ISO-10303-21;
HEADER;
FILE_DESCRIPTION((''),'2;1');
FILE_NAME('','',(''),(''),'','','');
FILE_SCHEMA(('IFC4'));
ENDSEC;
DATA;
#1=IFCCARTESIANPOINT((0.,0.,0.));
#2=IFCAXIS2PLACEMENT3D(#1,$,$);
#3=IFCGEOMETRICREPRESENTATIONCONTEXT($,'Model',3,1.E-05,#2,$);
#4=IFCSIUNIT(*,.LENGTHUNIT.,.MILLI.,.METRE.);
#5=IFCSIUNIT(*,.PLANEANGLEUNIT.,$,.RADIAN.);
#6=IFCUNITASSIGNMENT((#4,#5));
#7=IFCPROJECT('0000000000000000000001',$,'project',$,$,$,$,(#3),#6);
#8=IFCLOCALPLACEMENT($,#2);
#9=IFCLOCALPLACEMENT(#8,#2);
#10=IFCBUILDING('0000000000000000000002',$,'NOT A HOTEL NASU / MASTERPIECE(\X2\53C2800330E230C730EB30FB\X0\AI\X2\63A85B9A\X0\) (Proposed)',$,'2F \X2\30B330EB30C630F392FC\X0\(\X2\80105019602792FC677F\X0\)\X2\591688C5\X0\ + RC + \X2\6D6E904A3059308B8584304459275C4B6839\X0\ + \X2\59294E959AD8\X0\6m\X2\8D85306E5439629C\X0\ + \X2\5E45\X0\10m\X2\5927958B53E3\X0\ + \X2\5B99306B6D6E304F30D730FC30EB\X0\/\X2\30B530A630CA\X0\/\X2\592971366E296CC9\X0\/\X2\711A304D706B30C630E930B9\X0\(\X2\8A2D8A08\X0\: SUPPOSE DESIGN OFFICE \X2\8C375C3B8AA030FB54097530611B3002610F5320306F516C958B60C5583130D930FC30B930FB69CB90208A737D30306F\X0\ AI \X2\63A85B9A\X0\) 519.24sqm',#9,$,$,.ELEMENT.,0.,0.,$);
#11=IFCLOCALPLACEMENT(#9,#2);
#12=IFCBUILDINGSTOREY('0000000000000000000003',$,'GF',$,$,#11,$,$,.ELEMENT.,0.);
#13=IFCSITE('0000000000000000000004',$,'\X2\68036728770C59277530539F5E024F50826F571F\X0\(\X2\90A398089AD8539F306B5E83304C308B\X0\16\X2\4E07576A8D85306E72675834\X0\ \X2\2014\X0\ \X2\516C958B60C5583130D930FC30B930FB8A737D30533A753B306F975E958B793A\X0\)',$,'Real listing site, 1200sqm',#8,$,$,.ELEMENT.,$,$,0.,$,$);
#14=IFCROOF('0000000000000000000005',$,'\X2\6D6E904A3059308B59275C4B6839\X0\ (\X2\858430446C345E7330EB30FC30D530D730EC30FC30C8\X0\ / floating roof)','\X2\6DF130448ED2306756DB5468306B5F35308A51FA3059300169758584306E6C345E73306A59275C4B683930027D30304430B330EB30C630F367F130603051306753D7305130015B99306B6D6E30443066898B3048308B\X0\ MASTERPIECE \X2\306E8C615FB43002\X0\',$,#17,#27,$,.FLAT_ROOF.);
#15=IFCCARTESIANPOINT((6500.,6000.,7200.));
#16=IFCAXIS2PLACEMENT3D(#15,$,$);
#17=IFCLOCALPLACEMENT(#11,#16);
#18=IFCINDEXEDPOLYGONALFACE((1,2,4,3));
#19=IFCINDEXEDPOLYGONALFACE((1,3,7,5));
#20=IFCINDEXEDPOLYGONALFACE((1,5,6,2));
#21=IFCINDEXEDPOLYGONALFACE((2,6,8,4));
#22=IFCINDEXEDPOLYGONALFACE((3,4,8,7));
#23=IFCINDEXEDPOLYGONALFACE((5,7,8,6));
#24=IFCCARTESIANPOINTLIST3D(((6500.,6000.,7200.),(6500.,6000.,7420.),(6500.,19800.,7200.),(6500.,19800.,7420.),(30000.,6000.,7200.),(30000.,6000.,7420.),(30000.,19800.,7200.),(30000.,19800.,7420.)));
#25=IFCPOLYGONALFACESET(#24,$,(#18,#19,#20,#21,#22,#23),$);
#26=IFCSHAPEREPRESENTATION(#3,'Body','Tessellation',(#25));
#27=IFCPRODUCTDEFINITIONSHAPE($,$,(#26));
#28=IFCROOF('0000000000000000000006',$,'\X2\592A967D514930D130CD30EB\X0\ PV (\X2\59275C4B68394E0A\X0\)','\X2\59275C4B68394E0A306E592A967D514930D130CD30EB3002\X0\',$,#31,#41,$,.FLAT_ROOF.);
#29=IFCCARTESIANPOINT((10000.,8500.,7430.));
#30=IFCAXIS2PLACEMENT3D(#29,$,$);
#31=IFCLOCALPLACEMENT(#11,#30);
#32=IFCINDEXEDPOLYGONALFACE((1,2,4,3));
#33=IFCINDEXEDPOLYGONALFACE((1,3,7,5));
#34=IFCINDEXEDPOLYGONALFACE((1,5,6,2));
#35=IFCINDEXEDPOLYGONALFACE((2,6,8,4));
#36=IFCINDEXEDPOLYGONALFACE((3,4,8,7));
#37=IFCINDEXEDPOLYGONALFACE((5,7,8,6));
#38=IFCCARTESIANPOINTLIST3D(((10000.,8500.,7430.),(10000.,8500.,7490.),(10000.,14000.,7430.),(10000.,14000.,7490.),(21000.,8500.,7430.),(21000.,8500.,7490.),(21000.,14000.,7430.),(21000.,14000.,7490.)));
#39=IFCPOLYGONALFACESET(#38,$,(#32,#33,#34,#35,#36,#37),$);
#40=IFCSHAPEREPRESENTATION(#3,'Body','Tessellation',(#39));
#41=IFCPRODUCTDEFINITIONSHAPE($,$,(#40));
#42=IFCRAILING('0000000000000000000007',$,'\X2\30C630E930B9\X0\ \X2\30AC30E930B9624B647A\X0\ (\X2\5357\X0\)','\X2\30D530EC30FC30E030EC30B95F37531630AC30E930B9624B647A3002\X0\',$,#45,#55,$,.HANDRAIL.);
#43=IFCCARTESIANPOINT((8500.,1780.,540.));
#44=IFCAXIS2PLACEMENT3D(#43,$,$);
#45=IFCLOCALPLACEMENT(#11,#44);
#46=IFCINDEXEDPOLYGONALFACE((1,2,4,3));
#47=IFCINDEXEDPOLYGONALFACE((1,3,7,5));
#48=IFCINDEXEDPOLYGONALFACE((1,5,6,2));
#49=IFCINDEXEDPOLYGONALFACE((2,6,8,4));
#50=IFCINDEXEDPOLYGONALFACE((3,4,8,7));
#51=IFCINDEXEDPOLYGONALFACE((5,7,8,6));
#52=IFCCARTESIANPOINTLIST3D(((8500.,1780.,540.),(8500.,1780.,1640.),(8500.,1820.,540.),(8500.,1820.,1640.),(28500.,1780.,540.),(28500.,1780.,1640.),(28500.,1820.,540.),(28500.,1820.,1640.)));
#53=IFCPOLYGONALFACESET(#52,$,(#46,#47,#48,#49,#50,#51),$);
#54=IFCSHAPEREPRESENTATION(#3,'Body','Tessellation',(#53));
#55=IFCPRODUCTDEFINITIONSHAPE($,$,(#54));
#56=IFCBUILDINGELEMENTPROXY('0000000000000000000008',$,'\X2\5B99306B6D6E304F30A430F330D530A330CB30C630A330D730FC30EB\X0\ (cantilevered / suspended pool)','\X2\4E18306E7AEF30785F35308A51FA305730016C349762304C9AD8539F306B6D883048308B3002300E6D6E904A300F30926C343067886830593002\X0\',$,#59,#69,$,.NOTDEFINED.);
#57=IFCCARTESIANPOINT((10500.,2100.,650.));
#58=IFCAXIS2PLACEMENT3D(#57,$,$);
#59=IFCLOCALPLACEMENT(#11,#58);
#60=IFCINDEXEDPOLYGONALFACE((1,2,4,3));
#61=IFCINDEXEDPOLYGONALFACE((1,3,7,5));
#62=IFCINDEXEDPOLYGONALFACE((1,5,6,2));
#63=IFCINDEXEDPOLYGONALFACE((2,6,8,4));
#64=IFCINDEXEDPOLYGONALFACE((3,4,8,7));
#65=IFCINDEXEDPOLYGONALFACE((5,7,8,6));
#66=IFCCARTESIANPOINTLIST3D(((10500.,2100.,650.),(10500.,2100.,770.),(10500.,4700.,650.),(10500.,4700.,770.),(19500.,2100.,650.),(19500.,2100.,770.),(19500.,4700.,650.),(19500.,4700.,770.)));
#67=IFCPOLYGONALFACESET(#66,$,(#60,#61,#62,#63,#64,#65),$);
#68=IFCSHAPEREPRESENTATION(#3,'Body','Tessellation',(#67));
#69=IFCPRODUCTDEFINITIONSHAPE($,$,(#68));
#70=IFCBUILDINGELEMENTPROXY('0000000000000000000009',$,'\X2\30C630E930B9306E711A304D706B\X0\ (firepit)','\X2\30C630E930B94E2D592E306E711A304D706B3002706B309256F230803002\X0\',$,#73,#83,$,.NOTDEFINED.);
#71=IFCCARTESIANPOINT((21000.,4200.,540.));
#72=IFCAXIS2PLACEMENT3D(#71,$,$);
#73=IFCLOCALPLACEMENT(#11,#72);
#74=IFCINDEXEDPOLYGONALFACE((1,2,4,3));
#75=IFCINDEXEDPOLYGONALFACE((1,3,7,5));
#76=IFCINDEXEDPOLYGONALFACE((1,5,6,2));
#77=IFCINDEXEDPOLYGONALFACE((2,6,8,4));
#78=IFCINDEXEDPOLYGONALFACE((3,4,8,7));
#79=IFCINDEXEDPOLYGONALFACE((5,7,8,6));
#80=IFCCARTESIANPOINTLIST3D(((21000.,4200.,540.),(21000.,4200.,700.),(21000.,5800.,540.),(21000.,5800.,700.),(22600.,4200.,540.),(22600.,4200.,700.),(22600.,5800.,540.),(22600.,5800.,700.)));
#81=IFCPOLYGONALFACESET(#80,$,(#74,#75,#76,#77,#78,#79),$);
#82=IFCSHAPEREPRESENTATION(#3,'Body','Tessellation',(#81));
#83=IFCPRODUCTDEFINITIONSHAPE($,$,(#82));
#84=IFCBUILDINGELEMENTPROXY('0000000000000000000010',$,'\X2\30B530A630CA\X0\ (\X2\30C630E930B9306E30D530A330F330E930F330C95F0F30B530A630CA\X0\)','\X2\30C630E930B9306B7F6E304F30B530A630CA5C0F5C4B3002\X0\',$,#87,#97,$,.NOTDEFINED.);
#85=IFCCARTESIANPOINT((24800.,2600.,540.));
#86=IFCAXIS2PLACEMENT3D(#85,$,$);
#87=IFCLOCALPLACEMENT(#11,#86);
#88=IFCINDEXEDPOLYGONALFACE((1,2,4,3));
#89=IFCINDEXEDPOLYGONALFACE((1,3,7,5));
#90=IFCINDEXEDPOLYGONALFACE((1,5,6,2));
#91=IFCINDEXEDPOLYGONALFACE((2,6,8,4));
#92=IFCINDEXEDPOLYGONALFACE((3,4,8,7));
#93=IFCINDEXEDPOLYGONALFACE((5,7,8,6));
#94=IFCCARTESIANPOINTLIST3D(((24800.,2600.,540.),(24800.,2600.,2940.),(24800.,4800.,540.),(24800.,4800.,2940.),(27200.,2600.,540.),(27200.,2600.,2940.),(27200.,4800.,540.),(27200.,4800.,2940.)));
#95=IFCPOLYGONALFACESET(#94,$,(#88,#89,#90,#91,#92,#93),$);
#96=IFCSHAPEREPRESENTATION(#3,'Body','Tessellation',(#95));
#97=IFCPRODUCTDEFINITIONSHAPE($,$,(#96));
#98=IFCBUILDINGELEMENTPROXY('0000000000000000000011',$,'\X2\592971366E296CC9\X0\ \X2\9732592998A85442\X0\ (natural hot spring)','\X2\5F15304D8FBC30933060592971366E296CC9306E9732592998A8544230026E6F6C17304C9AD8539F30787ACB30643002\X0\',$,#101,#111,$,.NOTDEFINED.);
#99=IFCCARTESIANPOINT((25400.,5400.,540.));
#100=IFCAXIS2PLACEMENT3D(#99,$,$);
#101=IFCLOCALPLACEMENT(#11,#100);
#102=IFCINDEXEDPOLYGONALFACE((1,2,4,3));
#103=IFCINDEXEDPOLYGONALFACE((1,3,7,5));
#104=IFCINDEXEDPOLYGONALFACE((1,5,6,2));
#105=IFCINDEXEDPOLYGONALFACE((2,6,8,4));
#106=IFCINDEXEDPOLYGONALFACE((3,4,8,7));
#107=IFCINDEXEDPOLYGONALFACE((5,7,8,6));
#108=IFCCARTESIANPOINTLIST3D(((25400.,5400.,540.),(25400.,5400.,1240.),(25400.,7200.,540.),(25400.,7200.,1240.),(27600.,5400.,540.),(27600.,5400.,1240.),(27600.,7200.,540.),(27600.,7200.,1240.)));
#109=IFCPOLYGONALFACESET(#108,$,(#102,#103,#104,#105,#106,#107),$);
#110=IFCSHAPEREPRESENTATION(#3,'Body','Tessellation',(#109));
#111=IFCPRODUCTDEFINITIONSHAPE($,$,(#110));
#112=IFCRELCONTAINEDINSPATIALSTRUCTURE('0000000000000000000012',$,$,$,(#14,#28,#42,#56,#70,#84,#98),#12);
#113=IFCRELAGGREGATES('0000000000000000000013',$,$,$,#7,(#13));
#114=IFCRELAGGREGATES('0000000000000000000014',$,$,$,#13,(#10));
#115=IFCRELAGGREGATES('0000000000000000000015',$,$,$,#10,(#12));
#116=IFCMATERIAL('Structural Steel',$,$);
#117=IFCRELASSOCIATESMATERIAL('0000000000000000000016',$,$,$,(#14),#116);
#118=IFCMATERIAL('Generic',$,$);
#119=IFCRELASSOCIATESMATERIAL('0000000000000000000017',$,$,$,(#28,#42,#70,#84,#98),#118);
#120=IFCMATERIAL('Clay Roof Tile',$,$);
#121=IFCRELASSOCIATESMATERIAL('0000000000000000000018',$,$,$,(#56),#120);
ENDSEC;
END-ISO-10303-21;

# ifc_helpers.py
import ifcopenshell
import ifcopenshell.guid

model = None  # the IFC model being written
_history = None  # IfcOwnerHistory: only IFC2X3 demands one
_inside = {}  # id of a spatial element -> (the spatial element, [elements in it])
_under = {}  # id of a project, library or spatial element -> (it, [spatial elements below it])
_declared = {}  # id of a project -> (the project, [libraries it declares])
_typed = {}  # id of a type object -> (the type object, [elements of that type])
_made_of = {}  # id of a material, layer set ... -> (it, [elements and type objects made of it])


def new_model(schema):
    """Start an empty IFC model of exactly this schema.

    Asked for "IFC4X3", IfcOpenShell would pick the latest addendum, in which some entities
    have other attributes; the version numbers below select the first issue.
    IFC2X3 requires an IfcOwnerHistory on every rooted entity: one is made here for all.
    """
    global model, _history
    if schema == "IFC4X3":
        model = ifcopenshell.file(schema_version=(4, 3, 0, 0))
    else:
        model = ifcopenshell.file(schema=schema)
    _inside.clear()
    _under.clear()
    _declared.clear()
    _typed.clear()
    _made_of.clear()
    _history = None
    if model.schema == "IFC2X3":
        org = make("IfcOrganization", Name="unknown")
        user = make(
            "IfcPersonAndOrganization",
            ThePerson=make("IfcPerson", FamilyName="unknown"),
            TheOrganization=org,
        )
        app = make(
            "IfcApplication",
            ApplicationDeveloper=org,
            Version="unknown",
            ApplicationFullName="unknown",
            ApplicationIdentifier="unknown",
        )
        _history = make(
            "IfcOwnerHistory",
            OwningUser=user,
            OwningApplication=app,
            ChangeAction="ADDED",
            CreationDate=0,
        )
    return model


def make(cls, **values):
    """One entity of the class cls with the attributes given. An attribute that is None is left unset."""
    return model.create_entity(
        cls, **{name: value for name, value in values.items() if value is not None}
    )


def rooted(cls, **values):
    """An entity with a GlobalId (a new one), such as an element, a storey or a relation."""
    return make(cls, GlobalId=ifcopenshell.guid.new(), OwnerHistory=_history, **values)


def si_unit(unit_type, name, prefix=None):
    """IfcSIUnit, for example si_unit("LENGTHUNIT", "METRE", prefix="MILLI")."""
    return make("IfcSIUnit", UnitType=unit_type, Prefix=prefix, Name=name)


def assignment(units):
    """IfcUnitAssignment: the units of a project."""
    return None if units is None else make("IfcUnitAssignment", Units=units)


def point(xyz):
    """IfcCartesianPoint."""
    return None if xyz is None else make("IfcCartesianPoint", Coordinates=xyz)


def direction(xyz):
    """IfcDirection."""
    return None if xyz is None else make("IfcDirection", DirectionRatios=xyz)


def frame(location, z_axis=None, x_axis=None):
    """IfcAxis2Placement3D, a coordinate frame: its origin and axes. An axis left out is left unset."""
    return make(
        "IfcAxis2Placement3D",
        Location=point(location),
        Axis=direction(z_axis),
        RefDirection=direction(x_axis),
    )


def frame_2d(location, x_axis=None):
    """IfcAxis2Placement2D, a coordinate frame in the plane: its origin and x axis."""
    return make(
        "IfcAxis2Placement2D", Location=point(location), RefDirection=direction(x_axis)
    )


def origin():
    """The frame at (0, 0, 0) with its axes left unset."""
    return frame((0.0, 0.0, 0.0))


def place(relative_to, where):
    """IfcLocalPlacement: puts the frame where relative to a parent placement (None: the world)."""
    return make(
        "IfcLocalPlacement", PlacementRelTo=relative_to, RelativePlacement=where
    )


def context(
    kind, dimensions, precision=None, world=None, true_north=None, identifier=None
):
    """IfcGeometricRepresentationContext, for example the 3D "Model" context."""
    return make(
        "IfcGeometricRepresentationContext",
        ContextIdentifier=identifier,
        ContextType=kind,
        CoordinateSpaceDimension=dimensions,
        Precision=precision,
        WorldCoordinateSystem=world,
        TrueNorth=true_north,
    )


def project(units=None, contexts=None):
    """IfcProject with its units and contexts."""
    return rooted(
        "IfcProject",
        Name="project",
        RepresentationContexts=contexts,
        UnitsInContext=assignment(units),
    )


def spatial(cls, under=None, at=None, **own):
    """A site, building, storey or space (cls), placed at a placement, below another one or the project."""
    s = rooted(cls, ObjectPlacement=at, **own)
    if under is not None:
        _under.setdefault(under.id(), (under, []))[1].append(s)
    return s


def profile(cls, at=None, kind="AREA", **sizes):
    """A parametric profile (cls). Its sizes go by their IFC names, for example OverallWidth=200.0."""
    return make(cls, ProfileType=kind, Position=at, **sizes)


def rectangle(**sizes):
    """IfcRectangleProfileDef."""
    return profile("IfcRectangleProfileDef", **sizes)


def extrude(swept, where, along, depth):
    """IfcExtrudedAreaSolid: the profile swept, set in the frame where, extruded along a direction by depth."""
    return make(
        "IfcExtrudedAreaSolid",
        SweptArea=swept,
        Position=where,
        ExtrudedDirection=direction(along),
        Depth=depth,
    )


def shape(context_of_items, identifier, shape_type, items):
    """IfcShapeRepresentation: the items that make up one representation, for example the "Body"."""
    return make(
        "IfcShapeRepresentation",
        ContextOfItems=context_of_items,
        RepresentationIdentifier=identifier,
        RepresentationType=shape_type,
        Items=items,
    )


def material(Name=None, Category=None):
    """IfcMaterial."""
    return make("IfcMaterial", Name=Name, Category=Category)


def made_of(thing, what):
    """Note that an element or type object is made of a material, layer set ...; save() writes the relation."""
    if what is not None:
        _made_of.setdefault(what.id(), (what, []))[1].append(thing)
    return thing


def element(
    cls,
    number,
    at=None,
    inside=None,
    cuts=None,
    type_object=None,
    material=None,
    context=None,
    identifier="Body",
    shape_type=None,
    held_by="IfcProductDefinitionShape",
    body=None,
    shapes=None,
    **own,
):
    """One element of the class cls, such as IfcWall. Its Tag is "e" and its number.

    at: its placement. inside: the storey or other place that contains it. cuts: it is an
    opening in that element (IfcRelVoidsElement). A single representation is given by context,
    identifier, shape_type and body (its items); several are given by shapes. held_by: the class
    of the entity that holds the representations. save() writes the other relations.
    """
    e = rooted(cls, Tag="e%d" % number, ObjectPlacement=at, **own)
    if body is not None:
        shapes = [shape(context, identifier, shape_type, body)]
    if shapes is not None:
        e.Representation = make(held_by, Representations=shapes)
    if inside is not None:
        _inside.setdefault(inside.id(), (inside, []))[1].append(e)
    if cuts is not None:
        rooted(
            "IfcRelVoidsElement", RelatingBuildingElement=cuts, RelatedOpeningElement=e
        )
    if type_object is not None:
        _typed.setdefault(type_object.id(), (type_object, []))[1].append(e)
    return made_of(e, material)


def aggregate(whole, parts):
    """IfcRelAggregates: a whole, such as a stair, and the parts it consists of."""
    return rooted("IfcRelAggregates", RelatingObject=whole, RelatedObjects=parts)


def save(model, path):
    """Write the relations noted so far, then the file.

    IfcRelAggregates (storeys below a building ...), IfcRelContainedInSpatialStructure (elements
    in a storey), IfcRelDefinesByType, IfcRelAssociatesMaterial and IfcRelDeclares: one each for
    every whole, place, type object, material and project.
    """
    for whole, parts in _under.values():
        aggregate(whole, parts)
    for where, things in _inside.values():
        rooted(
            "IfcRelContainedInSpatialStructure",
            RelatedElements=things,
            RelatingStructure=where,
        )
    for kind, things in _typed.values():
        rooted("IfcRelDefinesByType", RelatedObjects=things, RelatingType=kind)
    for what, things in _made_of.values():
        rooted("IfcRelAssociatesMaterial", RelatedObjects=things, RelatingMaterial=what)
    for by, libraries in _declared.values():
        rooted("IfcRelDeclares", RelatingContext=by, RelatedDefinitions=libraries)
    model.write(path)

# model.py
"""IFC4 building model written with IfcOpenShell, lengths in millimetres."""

from ifc_helpers import new_model, si_unit, frame, frame_2d, origin, place, context, project, spatial, rectangle, extrude, material, element, save


model = new_model("IFC4")

# Units and contexts
model_context = context("Model", 3, precision=1e-05, world=origin())
ifc_project = project(units=[si_unit("LENGTHUNIT", "METRE", prefix="MILLI"), si_unit("PLANEANGLEUNIT", "RADIAN")], contexts=[model_context])

# Site, building, storey
site_placement = place(None, origin())
site = spatial("IfcSite", under=ifc_project, at=site_placement, Name="栃木県大田原市佐良土(那須高原に広がる16万坪超の牧場 — 公開情報ベース・詳細区画は非開示)", ObjectType="Real listing site, 1200sqm", CompositionType="ELEMENT", RefElevation=0.0)
building_placement = place(site_placement, origin())
building = spatial("IfcBuilding", under=site, at=building_placement, Name="NOT A HOTEL NASU / MASTERPIECE(参考モデル・AI推定) (Proposed)", ObjectType="2F コルテン鋼(耐候性鋼板)外装 + RC + 浮遊する薄い大屋根 + 天井高6m超の吹抜 + 幅10m大開口 + 宙に浮くプール/サウナ/天然温泉/焚き火テラス(設計: SUPPOSE DESIGN OFFICE 谷尻誠・吉田愛。意匠は公開情報ベース・構造詳細は AI 推定) 519.24sqm", CompositionType="ELEMENT", ElevationOfRefHeight=0.0, ElevationOfTerrain=0.0)
storey_placement = place(building_placement, origin())
storey = spatial("IfcBuildingStorey", under=building, at=storey_placement, Name="GF", CompositionType="ELEMENT", Elevation=0.0)

# Shared definitions
ifc_material_1 = material(Name="Generic")

# Shared definitions
ifc_material_2 = material(Name="Structural Steel")

# Roofs
roof_1_placement = place(storey_placement, frame((6500.0, 6000.0, 7200.0)))
element("IfcRoof", 1, at=roof_1_placement, inside=storey, material=ifc_material_2, Name="浮遊する大屋根 (薄い水平ルーフプレート / floating roof)", Description="深い軒で四周に張り出す、極薄の水平な大屋根。細いコルテン柱だけで受け、宙に浮いて見える MASTERPIECE の象徴。", PredefinedType="FLAT_ROOF", context=model_context, shape_type="SweptSolid", body=[
    extrude(rectangle(XDim=23500.0, YDim=13800.0, at=frame_2d((11750.0, 6900.0))), frame((6500.0, 6000.0, 7200.0)), (0.0, 0.0, 1.0), 220.0),
])
roof_2_placement = place(storey_placement, frame((10000.0, 8500.0, 7430.0)))
element("IfcRoof", 2, at=roof_2_placement, inside=storey, material=ifc_material_1, Name="太陽光パネル PV (大屋根上)", Description="大屋根上の太陽光パネル。", PredefinedType="FLAT_ROOF", context=model_context, shape_type="SweptSolid", body=[
    extrude(rectangle(XDim=11000.0, YDim=5500.0, at=frame_2d((5500.0, 2750.0))), frame((10000.0, 8500.0, 7430.0)), (0.0, 0.0, 1.0), 60.0),
])

# Railing
railing_placement = place(storey_placement, frame((8500.0, 1780.0, 540.0)))
element("IfcRailing", 3, at=railing_placement, inside=storey, material=ifc_material_1, Name="テラス ガラス手摺 (南)", Description="フレームレス強化ガラス手摺。", PredefinedType="HANDRAIL", context=model_context, shape_type="SweptSolid", body=[
    extrude(rectangle(XDim=20000.0, YDim=40.0, at=frame_2d((10000.0, 20.0))), frame((8500.0, 1780.0, 540.0)), (0.0, 0.0, 1.0), 1100.0),
])

# Building element proxies
ifc_material_3 = material(Name="Clay Roof Tile")
proxy_1_placement = place(storey_placement, frame((10500.0, 2100.0, 650.0)))
element("IfcBuildingElementProxy", 4, at=proxy_1_placement, inside=storey, material=ifc_material_3, Name="宙に浮くインフィニティプール (cantilevered / suspended pool)", Description="丘の端へ張り出し、水面が高原に消える。『浮遊』を水で表す。", PredefinedType="NOTDEFINED", context=model_context, shape_type="SweptSolid", body=[
    extrude(rectangle(XDim=9000.0, YDim=2600.0, at=frame_2d((4500.0, 1300.0))), frame((10500.0, 2100.0, 650.0)), (0.0, 0.0, 1.0), 120.0),
])
proxy_2_placement = place(storey_placement, frame((21000.0, 4200.0, 540.0)))
element("IfcBuildingElementProxy", 5, at=proxy_2_placement, inside=storey, material=ifc_material_1, Name="テラスの焚き火 (firepit)", Description="テラス中央の焚き火。火を囲む。", PredefinedType="NOTDEFINED", context=model_context, shape_type="SweptSolid", body=[
    extrude(rectangle(XDim=1600.0, YDim=1600.0, at=frame_2d((800.0, 800.0))), frame((21000.0, 4200.0, 540.0)), (0.0, 0.0, 1.0), 160.0),
])
proxy_3_placement = place(storey_placement, frame((24800.0, 2600.0, 540.0)))
element("IfcBuildingElementProxy", 6, at=proxy_3_placement, inside=storey, material=ifc_material_1, Name="サウナ (テラスのフィンランド式サウナ)", Description="テラスに置くサウナ小屋。", PredefinedType="NOTDEFINED", context=model_context, shape_type="SweptSolid", body=[
    extrude(rectangle(XDim=2400.0, YDim=2200.0, at=frame_2d((1200.0, 1100.0))), frame((24800.0, 2600.0, 540.0)), (0.0, 0.0, 1.0), 2400.0),
])
proxy_4_placement = place(storey_placement, frame((25400.0, 5400.0, 540.0)))
element("IfcBuildingElementProxy", 7, at=proxy_4_placement, inside=storey, material=ifc_material_1, Name="天然温泉 露天風呂 (natural hot spring)", Description="引き込んだ天然温泉の露天風呂。湯気が高原へ立つ。", PredefinedType="NOTDEFINED", context=model_context, shape_type="SweptSolid", body=[
    extrude(rectangle(XDim=2200.0, YDim=1800.0, at=frame_2d((1100.0, 900.0))), frame((25400.0, 5400.0, 540.0)), (0.0, 0.0, 1.0), 700.0),
])

save(model, "model.ifc")
